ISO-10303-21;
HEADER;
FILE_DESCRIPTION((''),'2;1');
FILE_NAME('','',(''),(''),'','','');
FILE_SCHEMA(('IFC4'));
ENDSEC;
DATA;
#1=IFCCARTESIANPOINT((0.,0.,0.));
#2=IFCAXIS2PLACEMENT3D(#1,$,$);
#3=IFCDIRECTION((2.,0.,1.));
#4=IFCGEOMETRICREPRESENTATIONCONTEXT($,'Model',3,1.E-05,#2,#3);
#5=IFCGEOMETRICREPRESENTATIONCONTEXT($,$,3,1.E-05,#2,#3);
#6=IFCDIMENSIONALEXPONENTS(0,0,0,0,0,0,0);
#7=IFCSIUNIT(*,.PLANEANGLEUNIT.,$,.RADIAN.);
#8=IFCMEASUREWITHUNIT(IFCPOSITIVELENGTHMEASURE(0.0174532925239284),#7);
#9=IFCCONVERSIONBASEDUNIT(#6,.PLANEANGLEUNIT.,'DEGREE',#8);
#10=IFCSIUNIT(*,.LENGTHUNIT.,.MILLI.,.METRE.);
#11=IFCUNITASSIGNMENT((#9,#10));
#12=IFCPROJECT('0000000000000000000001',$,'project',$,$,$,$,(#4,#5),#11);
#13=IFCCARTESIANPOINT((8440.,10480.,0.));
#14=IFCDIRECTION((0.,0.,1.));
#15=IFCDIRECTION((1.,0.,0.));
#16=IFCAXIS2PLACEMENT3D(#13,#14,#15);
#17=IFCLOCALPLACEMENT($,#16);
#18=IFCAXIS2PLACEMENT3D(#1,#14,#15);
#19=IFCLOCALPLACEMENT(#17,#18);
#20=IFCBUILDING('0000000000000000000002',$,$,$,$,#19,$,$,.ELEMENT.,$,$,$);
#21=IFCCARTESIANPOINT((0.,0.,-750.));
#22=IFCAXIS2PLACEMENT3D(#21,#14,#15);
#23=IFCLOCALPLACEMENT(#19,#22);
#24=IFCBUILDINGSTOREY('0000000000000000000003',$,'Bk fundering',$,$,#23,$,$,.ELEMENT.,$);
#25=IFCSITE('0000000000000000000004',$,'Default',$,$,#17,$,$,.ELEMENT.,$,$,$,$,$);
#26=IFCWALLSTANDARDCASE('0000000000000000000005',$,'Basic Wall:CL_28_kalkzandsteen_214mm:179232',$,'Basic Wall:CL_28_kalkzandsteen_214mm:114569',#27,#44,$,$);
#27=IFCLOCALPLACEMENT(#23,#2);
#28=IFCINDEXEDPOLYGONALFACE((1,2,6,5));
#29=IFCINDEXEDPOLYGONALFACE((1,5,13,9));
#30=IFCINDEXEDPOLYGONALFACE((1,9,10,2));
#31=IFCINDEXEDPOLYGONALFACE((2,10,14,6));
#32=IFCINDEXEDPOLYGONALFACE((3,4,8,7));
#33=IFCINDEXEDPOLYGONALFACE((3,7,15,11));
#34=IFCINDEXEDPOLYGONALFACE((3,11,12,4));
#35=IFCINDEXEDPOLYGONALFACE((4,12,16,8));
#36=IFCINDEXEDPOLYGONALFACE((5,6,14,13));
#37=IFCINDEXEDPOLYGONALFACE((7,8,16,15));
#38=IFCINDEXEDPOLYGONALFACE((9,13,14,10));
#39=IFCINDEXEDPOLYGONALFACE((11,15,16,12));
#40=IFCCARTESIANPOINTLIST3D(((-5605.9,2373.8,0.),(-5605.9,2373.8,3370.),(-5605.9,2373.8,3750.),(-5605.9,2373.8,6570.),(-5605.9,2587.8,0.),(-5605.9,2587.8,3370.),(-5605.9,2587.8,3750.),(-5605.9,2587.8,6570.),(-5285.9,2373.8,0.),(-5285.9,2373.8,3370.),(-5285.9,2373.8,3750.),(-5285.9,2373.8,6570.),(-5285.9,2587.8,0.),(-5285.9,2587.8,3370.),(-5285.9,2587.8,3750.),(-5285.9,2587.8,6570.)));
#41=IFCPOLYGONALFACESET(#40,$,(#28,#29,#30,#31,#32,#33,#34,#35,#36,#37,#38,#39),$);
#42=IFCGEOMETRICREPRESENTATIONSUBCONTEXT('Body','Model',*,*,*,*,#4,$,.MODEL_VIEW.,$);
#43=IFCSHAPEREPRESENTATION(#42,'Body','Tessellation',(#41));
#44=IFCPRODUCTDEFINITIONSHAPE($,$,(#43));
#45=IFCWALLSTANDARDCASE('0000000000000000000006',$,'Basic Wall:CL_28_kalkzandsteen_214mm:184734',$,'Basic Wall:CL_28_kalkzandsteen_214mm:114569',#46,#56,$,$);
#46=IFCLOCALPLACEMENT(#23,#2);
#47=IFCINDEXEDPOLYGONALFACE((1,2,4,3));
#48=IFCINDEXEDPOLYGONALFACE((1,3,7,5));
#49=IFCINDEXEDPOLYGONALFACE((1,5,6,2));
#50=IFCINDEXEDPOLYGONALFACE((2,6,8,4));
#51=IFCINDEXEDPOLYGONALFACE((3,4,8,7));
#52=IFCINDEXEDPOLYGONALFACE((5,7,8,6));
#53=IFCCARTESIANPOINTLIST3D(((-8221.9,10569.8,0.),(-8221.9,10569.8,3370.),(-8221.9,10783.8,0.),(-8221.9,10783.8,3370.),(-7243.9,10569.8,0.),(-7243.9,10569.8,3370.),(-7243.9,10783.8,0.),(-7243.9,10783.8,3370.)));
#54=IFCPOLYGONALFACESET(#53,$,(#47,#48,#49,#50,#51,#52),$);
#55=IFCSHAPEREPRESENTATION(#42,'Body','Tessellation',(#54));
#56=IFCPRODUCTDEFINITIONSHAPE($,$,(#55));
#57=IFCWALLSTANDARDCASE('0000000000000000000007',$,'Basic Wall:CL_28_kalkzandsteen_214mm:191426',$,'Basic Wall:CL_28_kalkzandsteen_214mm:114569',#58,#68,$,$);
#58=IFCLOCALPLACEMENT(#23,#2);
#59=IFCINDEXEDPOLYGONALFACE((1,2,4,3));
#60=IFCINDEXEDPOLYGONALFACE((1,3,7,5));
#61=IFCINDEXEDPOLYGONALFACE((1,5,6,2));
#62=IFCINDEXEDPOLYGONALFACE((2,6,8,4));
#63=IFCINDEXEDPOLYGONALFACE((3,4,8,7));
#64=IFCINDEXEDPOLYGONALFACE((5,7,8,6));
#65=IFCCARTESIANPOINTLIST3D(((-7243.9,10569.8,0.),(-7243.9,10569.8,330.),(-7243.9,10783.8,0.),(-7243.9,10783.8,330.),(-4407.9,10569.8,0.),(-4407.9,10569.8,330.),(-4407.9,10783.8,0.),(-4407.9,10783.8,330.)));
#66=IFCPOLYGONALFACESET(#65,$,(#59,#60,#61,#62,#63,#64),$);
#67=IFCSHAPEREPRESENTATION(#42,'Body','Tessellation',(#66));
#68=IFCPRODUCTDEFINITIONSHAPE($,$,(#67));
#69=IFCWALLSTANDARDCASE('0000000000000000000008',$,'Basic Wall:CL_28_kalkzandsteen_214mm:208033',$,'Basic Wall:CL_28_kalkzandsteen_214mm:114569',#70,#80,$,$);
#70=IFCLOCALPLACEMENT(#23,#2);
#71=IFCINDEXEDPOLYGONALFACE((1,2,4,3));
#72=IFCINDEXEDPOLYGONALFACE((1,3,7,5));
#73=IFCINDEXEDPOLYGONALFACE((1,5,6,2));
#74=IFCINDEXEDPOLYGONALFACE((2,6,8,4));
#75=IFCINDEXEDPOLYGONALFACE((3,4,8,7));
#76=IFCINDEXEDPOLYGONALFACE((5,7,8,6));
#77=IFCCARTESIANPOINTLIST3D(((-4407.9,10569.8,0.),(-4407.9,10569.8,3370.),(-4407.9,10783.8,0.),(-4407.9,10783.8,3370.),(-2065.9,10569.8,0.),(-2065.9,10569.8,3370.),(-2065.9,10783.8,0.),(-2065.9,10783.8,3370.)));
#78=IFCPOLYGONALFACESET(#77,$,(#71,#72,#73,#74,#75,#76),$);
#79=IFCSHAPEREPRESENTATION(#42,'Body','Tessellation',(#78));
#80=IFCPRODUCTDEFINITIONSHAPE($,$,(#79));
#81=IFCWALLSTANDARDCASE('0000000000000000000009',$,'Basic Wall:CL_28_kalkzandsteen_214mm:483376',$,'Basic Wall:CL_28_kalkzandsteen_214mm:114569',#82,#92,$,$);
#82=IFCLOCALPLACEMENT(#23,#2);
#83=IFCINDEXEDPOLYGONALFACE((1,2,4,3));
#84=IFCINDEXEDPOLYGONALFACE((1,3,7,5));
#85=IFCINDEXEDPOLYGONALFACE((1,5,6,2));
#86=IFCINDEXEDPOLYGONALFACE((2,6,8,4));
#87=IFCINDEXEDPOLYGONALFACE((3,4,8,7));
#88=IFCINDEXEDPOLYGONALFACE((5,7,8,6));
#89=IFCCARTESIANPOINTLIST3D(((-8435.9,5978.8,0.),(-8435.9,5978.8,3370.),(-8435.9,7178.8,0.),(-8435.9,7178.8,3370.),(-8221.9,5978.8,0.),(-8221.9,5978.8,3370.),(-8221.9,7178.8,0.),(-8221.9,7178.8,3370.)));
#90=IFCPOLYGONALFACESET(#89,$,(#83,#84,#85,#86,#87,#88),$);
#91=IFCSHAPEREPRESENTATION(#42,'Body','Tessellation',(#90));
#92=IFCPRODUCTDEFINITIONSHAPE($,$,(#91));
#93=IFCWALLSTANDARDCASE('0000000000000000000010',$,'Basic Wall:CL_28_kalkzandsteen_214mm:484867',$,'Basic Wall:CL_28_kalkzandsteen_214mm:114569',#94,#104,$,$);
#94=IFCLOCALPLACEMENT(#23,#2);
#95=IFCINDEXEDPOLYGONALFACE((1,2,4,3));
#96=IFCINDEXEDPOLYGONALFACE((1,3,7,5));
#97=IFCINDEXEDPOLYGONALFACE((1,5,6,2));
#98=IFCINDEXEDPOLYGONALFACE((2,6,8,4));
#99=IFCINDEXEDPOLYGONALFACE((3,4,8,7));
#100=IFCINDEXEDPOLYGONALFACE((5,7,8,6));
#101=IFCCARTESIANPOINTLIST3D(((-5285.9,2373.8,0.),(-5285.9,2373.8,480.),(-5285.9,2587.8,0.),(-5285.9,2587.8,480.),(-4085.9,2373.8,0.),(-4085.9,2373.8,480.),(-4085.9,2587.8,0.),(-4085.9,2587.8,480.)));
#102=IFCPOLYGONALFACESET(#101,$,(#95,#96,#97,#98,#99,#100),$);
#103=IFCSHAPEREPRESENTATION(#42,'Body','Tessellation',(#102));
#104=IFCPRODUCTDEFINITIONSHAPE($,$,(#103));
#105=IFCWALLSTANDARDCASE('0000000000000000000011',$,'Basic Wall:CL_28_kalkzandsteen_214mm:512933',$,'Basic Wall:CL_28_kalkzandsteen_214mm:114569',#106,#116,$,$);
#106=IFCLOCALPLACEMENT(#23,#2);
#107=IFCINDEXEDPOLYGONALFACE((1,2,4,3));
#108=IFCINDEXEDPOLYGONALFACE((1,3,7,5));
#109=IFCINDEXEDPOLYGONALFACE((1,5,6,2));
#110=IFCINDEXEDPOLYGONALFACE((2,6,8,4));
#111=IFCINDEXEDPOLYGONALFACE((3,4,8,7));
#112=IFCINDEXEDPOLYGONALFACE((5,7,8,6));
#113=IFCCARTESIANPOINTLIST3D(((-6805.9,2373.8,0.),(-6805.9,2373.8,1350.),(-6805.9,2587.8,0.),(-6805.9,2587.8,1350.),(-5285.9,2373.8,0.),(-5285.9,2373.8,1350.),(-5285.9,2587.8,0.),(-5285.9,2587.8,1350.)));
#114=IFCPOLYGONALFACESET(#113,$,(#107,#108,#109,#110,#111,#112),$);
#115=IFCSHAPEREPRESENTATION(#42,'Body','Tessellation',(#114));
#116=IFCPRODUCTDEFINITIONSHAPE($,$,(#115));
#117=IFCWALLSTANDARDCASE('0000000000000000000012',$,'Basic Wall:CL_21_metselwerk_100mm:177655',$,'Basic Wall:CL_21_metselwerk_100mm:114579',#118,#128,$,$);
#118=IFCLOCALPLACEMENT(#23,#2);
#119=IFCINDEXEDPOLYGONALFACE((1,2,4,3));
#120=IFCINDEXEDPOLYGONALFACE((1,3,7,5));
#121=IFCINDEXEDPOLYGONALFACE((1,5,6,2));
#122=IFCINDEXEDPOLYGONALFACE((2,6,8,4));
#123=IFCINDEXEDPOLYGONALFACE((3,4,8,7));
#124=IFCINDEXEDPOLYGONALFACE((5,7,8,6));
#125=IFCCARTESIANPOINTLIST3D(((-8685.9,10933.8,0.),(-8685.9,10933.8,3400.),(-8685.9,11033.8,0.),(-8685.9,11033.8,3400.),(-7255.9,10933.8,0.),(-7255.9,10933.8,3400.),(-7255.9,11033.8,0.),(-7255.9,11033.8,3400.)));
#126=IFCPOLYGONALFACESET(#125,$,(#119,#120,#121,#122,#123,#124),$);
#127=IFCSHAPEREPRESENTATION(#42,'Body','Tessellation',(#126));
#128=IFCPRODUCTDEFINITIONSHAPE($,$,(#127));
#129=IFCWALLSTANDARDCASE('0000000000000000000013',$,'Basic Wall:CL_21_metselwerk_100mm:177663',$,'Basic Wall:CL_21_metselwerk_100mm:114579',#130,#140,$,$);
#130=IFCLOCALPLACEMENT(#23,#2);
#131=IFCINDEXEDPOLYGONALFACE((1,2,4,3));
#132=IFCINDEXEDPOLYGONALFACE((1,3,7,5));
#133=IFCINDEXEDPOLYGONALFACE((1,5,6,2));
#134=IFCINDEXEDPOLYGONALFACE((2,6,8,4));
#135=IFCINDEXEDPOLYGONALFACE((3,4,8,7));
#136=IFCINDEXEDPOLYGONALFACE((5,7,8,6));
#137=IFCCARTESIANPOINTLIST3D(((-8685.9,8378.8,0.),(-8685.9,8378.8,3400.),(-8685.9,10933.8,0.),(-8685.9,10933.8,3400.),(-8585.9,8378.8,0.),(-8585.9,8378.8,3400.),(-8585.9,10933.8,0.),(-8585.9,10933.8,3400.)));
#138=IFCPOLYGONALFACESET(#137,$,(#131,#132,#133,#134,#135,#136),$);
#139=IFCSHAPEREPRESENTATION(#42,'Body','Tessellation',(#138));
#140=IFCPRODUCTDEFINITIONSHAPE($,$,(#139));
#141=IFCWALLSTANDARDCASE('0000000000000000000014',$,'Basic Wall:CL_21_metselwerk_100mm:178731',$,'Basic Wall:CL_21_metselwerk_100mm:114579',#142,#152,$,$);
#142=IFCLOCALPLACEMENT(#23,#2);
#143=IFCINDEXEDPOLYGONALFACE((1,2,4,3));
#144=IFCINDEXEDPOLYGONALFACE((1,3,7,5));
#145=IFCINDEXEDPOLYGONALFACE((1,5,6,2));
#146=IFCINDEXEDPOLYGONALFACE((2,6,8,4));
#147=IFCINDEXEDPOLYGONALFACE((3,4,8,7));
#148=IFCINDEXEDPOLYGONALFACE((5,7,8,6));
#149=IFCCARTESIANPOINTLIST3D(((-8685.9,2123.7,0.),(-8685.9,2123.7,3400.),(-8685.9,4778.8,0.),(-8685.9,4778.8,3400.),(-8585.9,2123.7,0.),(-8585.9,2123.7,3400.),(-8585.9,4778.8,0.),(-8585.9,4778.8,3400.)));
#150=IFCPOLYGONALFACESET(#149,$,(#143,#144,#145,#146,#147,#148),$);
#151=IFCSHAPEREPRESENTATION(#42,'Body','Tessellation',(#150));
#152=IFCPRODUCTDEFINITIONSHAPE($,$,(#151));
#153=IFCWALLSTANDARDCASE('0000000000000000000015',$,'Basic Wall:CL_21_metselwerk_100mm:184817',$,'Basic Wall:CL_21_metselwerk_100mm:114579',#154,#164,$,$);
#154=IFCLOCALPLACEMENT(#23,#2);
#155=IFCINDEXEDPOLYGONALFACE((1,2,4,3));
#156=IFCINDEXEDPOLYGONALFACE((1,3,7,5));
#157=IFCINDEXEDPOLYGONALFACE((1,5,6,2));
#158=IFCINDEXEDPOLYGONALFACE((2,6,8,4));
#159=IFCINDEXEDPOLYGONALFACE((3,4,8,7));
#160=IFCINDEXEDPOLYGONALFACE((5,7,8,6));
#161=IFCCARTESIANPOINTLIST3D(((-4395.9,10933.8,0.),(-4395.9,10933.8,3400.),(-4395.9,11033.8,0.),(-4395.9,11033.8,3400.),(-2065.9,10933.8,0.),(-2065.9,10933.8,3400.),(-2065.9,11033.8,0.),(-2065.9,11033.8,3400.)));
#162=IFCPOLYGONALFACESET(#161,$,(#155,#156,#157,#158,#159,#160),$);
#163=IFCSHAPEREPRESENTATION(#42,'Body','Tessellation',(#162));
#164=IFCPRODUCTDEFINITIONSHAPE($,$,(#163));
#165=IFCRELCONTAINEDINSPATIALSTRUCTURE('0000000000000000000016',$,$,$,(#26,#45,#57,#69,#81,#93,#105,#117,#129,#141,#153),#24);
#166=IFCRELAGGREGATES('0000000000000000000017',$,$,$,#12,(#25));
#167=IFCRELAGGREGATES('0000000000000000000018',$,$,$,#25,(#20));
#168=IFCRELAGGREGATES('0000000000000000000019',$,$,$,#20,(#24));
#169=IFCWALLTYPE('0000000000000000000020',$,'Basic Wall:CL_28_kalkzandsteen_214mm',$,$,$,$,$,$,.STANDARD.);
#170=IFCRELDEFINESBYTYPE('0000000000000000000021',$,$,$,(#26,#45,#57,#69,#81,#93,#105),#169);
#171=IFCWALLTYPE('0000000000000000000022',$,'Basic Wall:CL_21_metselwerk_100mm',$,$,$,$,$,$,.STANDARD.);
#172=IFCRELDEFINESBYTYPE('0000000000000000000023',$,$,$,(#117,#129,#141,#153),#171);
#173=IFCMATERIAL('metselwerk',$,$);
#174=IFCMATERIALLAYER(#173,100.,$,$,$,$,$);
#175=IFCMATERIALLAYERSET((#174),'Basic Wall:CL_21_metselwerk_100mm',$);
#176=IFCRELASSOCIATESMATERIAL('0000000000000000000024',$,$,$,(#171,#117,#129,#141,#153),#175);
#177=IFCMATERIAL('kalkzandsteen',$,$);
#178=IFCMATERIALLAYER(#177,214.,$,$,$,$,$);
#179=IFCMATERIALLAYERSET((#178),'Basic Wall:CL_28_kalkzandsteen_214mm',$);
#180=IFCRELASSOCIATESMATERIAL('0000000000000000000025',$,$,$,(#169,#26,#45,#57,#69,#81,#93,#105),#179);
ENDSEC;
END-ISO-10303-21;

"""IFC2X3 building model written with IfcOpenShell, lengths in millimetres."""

from ifc_helpers import new_model, entity, si_unit, converted_unit, direction, frame, frame_2d, origin, origin_with_axes, place, context, subcontext, project, spatial, polyline, rectangle, extrude, clip, bounded_halfspace, material, layer, layer_set, layer_usage, type_object, element, save


model = new_model("IFC2X3")

# Units and contexts
model_context = context("Model", 3, precision=1e-05, world=origin(), true_north=direction((2.0, 0.0, 1.0)))
context_of_model = context(None, 3, precision=1e-05, world=origin(), true_north=direction((2.0, 0.0, 1.0)))
body_context = subcontext(model_context, "Body", "Model", "MODEL_VIEW")
ifc_project = project(units=[converted_unit("PLANEANGLEUNIT", "DEGREE", entity("IfcPositiveLengthMeasure", 0.0174532925239284), si_unit("PLANEANGLEUNIT", "RADIAN"), dimensions=[0, 0, 0, 0, 0, 0, 0]), si_unit("LENGTHUNIT", "METRE", prefix="MILLI")], contexts=[model_context, context_of_model])

# Site, building, storey
site_placement = place(None, frame((8440.0, 10480.0, 0.0), z_axis=(0.0, 0.0, 1.0), x_axis=(1.0, 0.0, 0.0)))
site = spatial("IfcSite", under=ifc_project, at=site_placement, Name="Default", CompositionType="ELEMENT")
building_placement = place(site_placement, origin_with_axes())
building = spatial("IfcBuilding", under=site, at=building_placement, CompositionType="ELEMENT")
storey_placement = place(building_placement, frame((0.0, 0.0, -750.0), z_axis=(0.0, 0.0, 1.0), x_axis=(1.0, 0.0, 0.0)))
storey = spatial("IfcBuildingStorey", under=building, at=storey_placement, Name="Bk fundering", CompositionType="ELEMENT")

# Shared definitions
ifc_material_1 = material(Name="metselwerk")
ifc_layer_1 = layer(ifc_material_1, 100.0)
ifc_layer_set_1 = layer_set([ifc_layer_1], Name="Basic Wall:CL_21_metselwerk_100mm")
wall_type_1 = type_object("IfcWallType", Name="Basic Wall:CL_21_metselwerk_100mm", PredefinedType="STANDARD", material=ifc_layer_set_1)
ifc_material_2 = material(Name="kalkzandsteen")
ifc_layer_2 = layer(ifc_material_2, 214.0)
ifc_layer_set_2 = layer_set([ifc_layer_2], Name="Basic Wall:CL_28_kalkzandsteen_214mm")
wall_type_2 = type_object("IfcWallType", Name="Basic Wall:CL_28_kalkzandsteen_214mm", PredefinedType="STANDARD", material=ifc_layer_set_2)

# Wall, opening
ifc_layer_usage_1 = layer_usage(ifc_layer_set_2, "AXIS2", "NEGATIVE", 107.0)
wall_1_placement = place(storey_placement, frame((-5605.9, 2480.8, 0.0), z_axis=(0.0, 0.0, 1.0), x_axis=(1.0, 0.0, 0.0)))
wall_1 = element("IfcWallStandardCase", 1, at=wall_1_placement, inside=storey, type_object=wall_type_2, material=ifc_layer_usage_1, Name="Basic Wall:CL_28_kalkzandsteen_214mm:179232", ObjectType="Basic Wall:CL_28_kalkzandsteen_214mm:114569", context=body_context, shape_type="SweptSolid", body=[
    extrude(rectangle(XDim=320.0, YDim=214.0, at=frame_2d((160.0, 0.0), x_axis=(-1.0, 0.0))), origin(), (0.0, 0.0, 1.0), 6570.0),
])
opening_1_placement = place(wall_1_placement, origin_with_axes())
element("IfcOpeningElement", 2, at=opening_1_placement, cuts=wall_1, ObjectType="Opening", context=body_context, shape_type="SweptSolid", body=[
    extrude(rectangle(XDim=320.0, YDim=214.0, at=frame_2d((0.0, 0.0), x_axis=(1.0, 0.0))), frame((160.0, 0.0, 3370.0)), (0.0, 0.0, 1.0), 380.0),
])

# Walls
ifc_layer_usage_2 = layer_usage(ifc_layer_set_2, "AXIS2", "NEGATIVE", 107.0)
wall_2_placement = place(storey_placement, frame((-7243.9, 10676.8, 0.0), z_axis=(0.0, 0.0, 1.0), x_axis=(-1.0, 0.0, 0.0)))
element("IfcWallStandardCase", 3, at=wall_2_placement, inside=storey, type_object=wall_type_2, material=ifc_layer_usage_2, Name="Basic Wall:CL_28_kalkzandsteen_214mm:184734", ObjectType="Basic Wall:CL_28_kalkzandsteen_214mm:114569", context=body_context, shape_type="Clipping", body=[
    clip(extrude(rectangle(XDim=978.0, YDim=214.0, at=frame_2d((489.0, 0.0), x_axis=(-1.0, 0.0))), origin(), (0.0, 0.0, 1.0), 3370.0), bounded_halfspace(frame((0.0, -107.0, 3370.0), z_axis=(0.0, 0.0, -1.0), x_axis=(-1.0, 0.0, 0.0)), True, frame((0.0, -107.0, 3370.0)), polyline([(0.0, 0.0), (978.0, 0.0), (978.0, 214.0), (0.0, 214.0), (0.0, 0.0)]))),
])
ifc_layer_usage_3 = layer_usage(ifc_layer_set_2, "AXIS2", "NEGATIVE", 107.0)
wall_3_placement = place(storey_placement, frame((-4407.9, 10676.8, 0.0), z_axis=(0.0, 0.0, 1.0), x_axis=(-1.0, 0.0, 0.0)))
element("IfcWallStandardCase", 4, at=wall_3_placement, inside=storey, type_object=wall_type_2, material=ifc_layer_usage_3, Name="Basic Wall:CL_28_kalkzandsteen_214mm:191426", ObjectType="Basic Wall:CL_28_kalkzandsteen_214mm:114569", context=body_context, shape_type="SweptSolid", body=[
    extrude(rectangle(XDim=2836.0, YDim=214.0, at=frame_2d((1418.0, 0.0), x_axis=(-1.0, 0.0))), origin(), (0.0, 0.0, 1.0), 330.0),
])
ifc_layer_usage_4 = layer_usage(ifc_layer_set_2, "AXIS2", "NEGATIVE", 107.0)
wall_4_placement = place(storey_placement, frame((-2065.9, 10676.8, 0.0), z_axis=(0.0, 0.0, 1.0), x_axis=(-1.0, 0.0, 0.0)))
element("IfcWallStandardCase", 5, at=wall_4_placement, inside=storey, type_object=wall_type_2, material=ifc_layer_usage_4, Name="Basic Wall:CL_28_kalkzandsteen_214mm:208033", ObjectType="Basic Wall:CL_28_kalkzandsteen_214mm:114569", context=body_context, shape_type="Clipping", body=[
    clip(extrude(rectangle(XDim=2342.0, YDim=214.0, at=frame_2d((1171.0, 0.0), x_axis=(-1.0, 0.0))), origin(), (0.0, 0.0, 1.0), 3370.0), bounded_halfspace(frame((0.0, -107.0, 3370.0), z_axis=(0.0, 0.0, -1.0), x_axis=(-1.0, 0.0, 0.0)), True, frame((0.0, -107.0, 3370.0)), polyline([(0.0, 0.0), (2342.0, 0.0), (2342.0, 214.0), (0.0, 214.0), (0.0, 0.0)]))),
])
ifc_layer_usage_5 = layer_usage(ifc_layer_set_2, "AXIS2", "NEGATIVE", 107.0)
wall_5_placement = place(storey_placement, frame((-8328.9, 7178.8, 0.0), z_axis=(0.0, 0.0, 1.0), x_axis=(0.0, -1.0, 0.0)))
element("IfcWallStandardCase", 6, at=wall_5_placement, inside=storey, type_object=wall_type_2, material=ifc_layer_usage_5, Name="Basic Wall:CL_28_kalkzandsteen_214mm:483376", ObjectType="Basic Wall:CL_28_kalkzandsteen_214mm:114569", context=body_context, shape_type="Clipping", body=[
    clip(extrude(rectangle(XDim=1200.0, YDim=214.0, at=frame_2d((600.0, 0.0), x_axis=(-1.0, 0.0))), origin(), (0.0, 0.0, 1.0), 3370.0), bounded_halfspace(frame((0.0, -107.0, 3370.0), z_axis=(0.0, 0.0, -1.0), x_axis=(0.0, 1.0, 0.0)), True, frame((0.0, -107.0, 3370.0)), polyline([(0.0, 0.0), (1200.0, 0.0), (1200.0, 214.0), (0.0, 214.0), (0.0, 0.0)]))),
])
ifc_layer_usage_6 = layer_usage(ifc_layer_set_2, "AXIS2", "NEGATIVE", 107.0)
wall_6_placement = place(storey_placement, frame((-5285.9, 2480.8, 0.0), z_axis=(0.0, 0.0, 1.0), x_axis=(1.0, 0.0, 0.0)))
element("IfcWallStandardCase", 7, at=wall_6_placement, inside=storey, type_object=wall_type_2, material=ifc_layer_usage_6, Name="Basic Wall:CL_28_kalkzandsteen_214mm:484867", ObjectType="Basic Wall:CL_28_kalkzandsteen_214mm:114569", context=body_context, shape_type="SweptSolid", body=[
    extrude(rectangle(XDim=1200.0, YDim=214.0, at=frame_2d((600.0, 0.0), x_axis=(-1.0, 0.0))), origin(), (0.0, 0.0, 1.0), 480.0),
])
ifc_layer_usage_7 = layer_usage(ifc_layer_set_2, "AXIS2", "NEGATIVE", 107.0)
wall_7_placement = place(storey_placement, frame((-6805.9, 2480.8, 0.0), z_axis=(0.0, 0.0, 1.0), x_axis=(1.0, 0.0, 0.0)))
element("IfcWallStandardCase", 8, at=wall_7_placement, inside=storey, type_object=wall_type_2, material=ifc_layer_usage_7, Name="Basic Wall:CL_28_kalkzandsteen_214mm:512933", ObjectType="Basic Wall:CL_28_kalkzandsteen_214mm:114569", context=body_context, shape_type="SweptSolid", body=[
    extrude(rectangle(XDim=1520.0, YDim=214.0, at=frame_2d((760.0, 0.0), x_axis=(-1.0, 0.0))), origin(), (0.0, 0.0, 1.0), 1350.0),
])
ifc_layer_usage_8 = layer_usage(ifc_layer_set_1, "AXIS2", "NEGATIVE", 50.0)
wall_8_placement = place(storey_placement, frame((-7255.9, 10983.8, 0.0), z_axis=(0.0, 0.0, 1.0), x_axis=(-1.0, 0.0, 0.0)))
element("IfcWallStandardCase", 9, at=wall_8_placement, inside=storey, type_object=wall_type_1, material=ifc_layer_usage_8, Name="Basic Wall:CL_21_metselwerk_100mm:177655", ObjectType="Basic Wall:CL_21_metselwerk_100mm:114579", context=body_context, shape_type="SweptSolid", body=[
    extrude(rectangle(XDim=1430.0, YDim=100.0, at=frame_2d((715.0, 0.0), x_axis=(-1.0, 0.0))), origin(), (0.0, 0.0, 1.0), 3400.0),
])
ifc_layer_usage_9 = layer_usage(ifc_layer_set_1, "AXIS2", "NEGATIVE", 50.0)
wall_9_placement = place(storey_placement, frame((-8635.9, 10933.8, 0.0), z_axis=(0.0, 0.0, 1.0), x_axis=(0.0, -1.0, 0.0)))
element("IfcWallStandardCase", 10, at=wall_9_placement, inside=storey, type_object=wall_type_1, material=ifc_layer_usage_9, Name="Basic Wall:CL_21_metselwerk_100mm:177663", ObjectType="Basic Wall:CL_21_metselwerk_100mm:114579", context=body_context, shape_type="SweptSolid", body=[
    extrude(rectangle(XDim=2555.0, YDim=100.0, at=frame_2d((1277.5, 0.0), x_axis=(-1.0, 0.0))), origin(), (0.0, 0.0, 1.0), 3400.0),
])
ifc_layer_usage_10 = layer_usage(ifc_layer_set_1, "AXIS2", "NEGATIVE", 50.0)
wall_10_placement = place(storey_placement, frame((-8635.9, 4778.8, 0.0), z_axis=(0.0, 0.0, 1.0), x_axis=(0.0, -1.0, 0.0)))
element("IfcWallStandardCase", 11, at=wall_10_placement, inside=storey, type_object=wall_type_1, material=ifc_layer_usage_10, Name="Basic Wall:CL_21_metselwerk_100mm:178731", ObjectType="Basic Wall:CL_21_metselwerk_100mm:114579", context=body_context, shape_type="SweptSolid", body=[
    extrude(rectangle(XDim=2655.1, YDim=100.0, at=frame_2d((1327.5, 0.0), x_axis=(-1.0, 0.0))), origin(), (0.0, 0.0, 1.0), 3400.0),
])
ifc_layer_usage_11 = layer_usage(ifc_layer_set_1, "AXIS2", "NEGATIVE", 50.0)
wall_11_placement = place(storey_placement, frame((-2065.9, 10983.8, 0.0), z_axis=(0.0, 0.0, 1.0), x_axis=(-1.0, 0.0, 0.0)))
element("IfcWallStandardCase", 12, at=wall_11_placement, inside=storey, type_object=wall_type_1, material=ifc_layer_usage_11, Name="Basic Wall:CL_21_metselwerk_100mm:184817", ObjectType="Basic Wall:CL_21_metselwerk_100mm:114579", context=body_context, shape_type="SweptSolid", body=[
    extrude(rectangle(XDim=2330.0, YDim=100.0, at=frame_2d((1165.0, 0.0), x_axis=(-1.0, 0.0))), origin(), (0.0, 0.0, 1.0), 3400.0),
])

save(model, "model.ifc")
